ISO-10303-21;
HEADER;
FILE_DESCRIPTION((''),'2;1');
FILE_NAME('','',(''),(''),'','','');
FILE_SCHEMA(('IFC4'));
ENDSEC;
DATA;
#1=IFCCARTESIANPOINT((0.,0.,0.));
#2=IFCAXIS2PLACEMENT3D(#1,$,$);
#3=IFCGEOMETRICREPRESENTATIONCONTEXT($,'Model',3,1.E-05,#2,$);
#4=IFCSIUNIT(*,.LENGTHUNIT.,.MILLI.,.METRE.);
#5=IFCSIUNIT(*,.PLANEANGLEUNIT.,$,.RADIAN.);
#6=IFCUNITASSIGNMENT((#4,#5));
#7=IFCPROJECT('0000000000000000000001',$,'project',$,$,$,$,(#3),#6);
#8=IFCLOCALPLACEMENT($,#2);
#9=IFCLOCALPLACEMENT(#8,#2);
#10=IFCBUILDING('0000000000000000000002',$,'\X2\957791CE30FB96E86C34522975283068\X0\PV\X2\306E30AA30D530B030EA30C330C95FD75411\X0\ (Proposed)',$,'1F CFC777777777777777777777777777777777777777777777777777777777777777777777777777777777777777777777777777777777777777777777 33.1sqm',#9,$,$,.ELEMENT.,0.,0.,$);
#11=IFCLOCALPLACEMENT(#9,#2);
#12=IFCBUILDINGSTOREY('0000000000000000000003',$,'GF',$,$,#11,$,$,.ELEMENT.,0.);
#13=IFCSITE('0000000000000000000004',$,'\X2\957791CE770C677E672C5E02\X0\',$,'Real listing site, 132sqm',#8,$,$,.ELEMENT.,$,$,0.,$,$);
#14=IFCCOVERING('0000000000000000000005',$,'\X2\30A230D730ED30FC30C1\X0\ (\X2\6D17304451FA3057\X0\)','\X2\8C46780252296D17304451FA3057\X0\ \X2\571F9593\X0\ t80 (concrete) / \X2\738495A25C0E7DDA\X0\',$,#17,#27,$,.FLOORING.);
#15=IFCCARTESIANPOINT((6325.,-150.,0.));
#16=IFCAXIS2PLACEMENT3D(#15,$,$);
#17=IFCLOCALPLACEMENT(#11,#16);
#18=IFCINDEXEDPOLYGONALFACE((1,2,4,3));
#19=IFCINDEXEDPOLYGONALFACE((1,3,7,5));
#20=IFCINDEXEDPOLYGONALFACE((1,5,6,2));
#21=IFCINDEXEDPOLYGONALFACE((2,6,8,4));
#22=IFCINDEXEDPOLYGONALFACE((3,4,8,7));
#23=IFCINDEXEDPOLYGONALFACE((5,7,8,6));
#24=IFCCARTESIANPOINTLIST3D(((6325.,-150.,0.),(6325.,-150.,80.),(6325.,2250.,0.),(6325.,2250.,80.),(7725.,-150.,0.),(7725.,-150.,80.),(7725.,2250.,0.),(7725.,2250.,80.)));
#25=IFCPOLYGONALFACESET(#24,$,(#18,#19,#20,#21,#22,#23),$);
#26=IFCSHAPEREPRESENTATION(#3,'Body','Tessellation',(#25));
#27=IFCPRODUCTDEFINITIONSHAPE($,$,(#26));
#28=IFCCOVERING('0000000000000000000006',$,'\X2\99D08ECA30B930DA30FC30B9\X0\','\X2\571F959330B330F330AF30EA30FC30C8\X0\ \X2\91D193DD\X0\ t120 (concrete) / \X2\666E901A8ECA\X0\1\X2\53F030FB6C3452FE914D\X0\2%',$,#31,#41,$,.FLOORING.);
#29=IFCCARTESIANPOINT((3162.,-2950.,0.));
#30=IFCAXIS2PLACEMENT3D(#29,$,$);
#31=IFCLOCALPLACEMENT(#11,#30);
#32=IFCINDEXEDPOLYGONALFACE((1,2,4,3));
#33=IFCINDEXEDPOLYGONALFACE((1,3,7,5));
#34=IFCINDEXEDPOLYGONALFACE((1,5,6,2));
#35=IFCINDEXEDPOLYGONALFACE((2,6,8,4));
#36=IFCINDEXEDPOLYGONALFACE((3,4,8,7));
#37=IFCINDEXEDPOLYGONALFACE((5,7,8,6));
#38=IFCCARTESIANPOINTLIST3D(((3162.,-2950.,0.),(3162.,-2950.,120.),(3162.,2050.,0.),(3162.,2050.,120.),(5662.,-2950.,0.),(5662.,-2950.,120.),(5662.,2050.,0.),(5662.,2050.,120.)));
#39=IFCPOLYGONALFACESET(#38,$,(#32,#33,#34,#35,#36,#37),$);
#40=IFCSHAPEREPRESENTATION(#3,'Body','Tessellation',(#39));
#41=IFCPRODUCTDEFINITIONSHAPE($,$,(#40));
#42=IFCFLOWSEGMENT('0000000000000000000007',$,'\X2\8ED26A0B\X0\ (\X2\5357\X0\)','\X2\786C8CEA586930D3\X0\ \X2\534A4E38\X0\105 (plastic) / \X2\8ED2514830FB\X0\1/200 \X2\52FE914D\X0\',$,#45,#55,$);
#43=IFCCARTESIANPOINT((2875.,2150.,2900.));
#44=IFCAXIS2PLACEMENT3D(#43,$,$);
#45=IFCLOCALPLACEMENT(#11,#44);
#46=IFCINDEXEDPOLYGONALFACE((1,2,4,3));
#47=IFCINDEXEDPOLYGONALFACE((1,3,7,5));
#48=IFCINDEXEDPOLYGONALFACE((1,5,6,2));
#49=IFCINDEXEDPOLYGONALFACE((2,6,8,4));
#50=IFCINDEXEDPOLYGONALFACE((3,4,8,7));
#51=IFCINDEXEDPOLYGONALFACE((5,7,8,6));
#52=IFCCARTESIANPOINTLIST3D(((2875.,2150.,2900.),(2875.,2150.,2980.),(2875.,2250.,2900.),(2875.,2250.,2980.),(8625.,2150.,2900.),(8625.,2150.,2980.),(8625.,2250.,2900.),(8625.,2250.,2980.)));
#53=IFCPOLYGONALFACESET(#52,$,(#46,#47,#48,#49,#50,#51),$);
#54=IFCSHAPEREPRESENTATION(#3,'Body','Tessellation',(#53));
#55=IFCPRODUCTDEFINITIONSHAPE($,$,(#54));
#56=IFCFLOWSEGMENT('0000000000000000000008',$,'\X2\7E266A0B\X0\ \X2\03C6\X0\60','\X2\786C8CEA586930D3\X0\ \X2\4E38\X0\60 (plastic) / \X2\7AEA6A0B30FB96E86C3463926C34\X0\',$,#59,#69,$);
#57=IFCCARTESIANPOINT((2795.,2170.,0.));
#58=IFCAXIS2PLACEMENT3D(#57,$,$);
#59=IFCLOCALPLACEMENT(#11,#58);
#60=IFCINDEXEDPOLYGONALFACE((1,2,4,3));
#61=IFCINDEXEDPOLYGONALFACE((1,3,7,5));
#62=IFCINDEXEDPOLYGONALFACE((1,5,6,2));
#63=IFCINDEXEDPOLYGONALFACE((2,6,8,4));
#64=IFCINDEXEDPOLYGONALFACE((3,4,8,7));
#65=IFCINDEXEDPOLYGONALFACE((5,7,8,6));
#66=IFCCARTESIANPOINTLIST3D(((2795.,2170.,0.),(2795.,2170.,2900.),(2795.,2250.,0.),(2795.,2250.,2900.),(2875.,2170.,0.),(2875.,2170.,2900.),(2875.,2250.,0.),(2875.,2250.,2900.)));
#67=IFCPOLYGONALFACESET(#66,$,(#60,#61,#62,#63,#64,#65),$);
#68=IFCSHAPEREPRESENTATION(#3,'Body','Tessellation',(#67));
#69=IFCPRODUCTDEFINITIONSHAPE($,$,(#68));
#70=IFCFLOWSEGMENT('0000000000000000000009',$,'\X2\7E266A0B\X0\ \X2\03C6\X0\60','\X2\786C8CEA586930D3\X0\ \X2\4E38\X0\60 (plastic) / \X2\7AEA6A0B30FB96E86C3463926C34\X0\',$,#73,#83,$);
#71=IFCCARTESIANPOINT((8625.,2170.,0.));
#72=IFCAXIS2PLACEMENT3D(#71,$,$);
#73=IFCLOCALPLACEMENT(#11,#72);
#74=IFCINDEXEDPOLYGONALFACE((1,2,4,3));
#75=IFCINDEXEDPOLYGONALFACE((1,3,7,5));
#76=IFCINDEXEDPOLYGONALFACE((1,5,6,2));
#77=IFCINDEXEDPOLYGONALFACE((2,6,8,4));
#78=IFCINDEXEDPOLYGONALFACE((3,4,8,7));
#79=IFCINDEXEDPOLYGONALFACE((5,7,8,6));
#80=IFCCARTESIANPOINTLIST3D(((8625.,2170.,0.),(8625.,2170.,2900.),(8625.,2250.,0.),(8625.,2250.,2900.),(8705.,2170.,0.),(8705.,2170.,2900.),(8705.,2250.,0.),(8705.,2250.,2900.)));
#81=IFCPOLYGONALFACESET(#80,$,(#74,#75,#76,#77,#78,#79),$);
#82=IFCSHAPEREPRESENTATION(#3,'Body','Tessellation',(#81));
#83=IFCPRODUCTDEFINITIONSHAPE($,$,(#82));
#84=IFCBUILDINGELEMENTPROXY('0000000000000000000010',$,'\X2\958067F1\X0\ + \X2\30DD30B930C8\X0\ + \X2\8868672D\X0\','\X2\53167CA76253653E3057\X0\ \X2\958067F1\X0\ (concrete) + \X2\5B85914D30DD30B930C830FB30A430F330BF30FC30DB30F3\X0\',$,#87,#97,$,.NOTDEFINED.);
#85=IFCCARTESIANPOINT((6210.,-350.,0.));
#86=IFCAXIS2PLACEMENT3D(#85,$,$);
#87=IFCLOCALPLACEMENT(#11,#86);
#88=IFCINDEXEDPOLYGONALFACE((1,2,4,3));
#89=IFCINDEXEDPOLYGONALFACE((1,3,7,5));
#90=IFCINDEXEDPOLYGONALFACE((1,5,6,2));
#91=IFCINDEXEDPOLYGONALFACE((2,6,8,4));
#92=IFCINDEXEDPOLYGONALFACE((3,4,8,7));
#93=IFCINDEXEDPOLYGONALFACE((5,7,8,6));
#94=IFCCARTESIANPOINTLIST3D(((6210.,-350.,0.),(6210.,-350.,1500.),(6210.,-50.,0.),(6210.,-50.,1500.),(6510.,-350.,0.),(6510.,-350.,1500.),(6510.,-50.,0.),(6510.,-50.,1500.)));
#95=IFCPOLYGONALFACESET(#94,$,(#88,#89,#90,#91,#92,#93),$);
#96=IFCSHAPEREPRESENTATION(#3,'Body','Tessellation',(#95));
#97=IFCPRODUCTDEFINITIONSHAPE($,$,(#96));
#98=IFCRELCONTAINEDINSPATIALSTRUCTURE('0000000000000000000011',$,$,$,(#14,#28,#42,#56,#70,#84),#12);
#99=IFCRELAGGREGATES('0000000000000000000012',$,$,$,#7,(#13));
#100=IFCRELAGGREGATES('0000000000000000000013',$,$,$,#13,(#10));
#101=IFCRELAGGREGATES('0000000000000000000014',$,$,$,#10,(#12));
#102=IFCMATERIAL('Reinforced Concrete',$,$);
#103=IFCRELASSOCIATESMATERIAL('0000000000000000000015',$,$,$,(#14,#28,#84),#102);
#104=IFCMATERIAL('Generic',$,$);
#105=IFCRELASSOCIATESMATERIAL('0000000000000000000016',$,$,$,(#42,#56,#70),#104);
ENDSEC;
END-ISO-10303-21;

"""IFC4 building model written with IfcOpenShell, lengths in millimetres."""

from ifc_helpers import new_model, si_unit, frame, frame_2d, origin, place, context, project, spatial, rectangle, extrude, material, element, save


model = new_model("IFC4")

# Units and contexts
model_context = context("Model", 3, precision=1e-05, world=origin())
ifc_project = project(units=[si_unit("LENGTHUNIT", "METRE", prefix="MILLI"), si_unit("PLANEANGLEUNIT", "RADIAN")], contexts=[model_context])

# Site, building, storey
site_placement = place(None, origin())
site = spatial("IfcSite", under=ifc_project, at=site_placement, Name="長野県松本市", ObjectType="Real listing site, 132sqm", CompositionType="ELEMENT", RefElevation=0.0)
building_placement = place(site_placement, origin())
building = spatial("IfcBuilding", under=site, at=building_placement, Name="長野・雨水利用とPVのオフグリッド志向 (Proposed)", ObjectType="1F CFC777777777777777777777777777777777777777777777777777777777777777777777777777777777777777777777777777777777777777777777 33.1sqm", CompositionType="ELEMENT", ElevationOfRefHeight=0.0, ElevationOfTerrain=0.0)
storey_placement = place(building_placement, origin())
storey = spatial("IfcBuildingStorey", under=building, at=storey_placement, Name="GF", CompositionType="ELEMENT", Elevation=0.0)

# Shared definitions
ifc_material_1 = material(Name="Reinforced Concrete")

# Coverings
ifc_material_2 = material(Name="Generic")
covering_1_placement = place(storey_placement, frame((6325.0, -150.0, 0.0)))
element("IfcCovering", 1, at=covering_1_placement, inside=storey, material=ifc_material_1, Name="アプローチ (洗い出し)", Description="豆砂利洗い出し 土間 t80 (concrete) / 玄関導線", PredefinedType="FLOORING", context=model_context, shape_type="SweptSolid", body=[
    extrude(rectangle(XDim=1400.0, YDim=2400.0, at=frame_2d((700.0, 1200.0))), frame((6325.0, -150.0, 0.0)), (0.0, 0.0, 1.0), 80.0),
])
covering_2_placement = place(storey_placement, frame((3162.0, -2950.0, 0.0)))
element("IfcCovering", 2, at=covering_2_placement, inside=storey, material=ifc_material_1, Name="駐車スペース", Description="土間コンクリート 金鏝 t120 (concrete) / 普通車1台・水勾配2%", PredefinedType="FLOORING", context=model_context, shape_type="SweptSolid", body=[
    extrude(rectangle(XDim=2500.0, YDim=5000.0, at=frame_2d((1250.0, 2500.0))), frame((3162.0, -2950.0, 0.0)), (0.0, 0.0, 1.0), 120.0),
])

# Flow segments
flow_segment_1_placement = place(storey_placement, frame((2875.0, 2150.0, 2900.0)))
element("IfcFlowSegment", 3, at=flow_segment_1_placement, inside=storey, material=ifc_material_2, Name="軒樋 (南)", Description="硬質塩ビ 半丸105 (plastic) / 軒先・1/200 勾配", context=model_context, shape_type="SweptSolid", body=[
    extrude(rectangle(XDim=5750.0, YDim=100.0, at=frame_2d((2875.0, 50.0))), frame((2875.0, 2150.0, 2900.0)), (0.0, 0.0, 1.0), 80.0),
])
flow_segment_2_placement = place(storey_placement, frame((2795.0, 2170.0, 0.0)))
element("IfcFlowSegment", 4, at=flow_segment_2_placement, inside=storey, material=ifc_material_2, Name="縦樋 φ60", Description="硬質塩ビ 丸60 (plastic) / 竪樋・雨水排水", context=model_context, shape_type="SweptSolid", body=[
    extrude(rectangle(XDim=80.0, YDim=80.0, at=frame_2d((40.0, 40.0))), frame((2795.0, 2170.0, 0.0)), (0.0, 0.0, 1.0), 2900.0),
])
flow_segment_3_placement = place(storey_placement, frame((8625.0, 2170.0, 0.0)))
element("IfcFlowSegment", 5, at=flow_segment_3_placement, inside=storey, material=ifc_material_2, Name="縦樋 φ60", Description="硬質塩ビ 丸60 (plastic) / 竪樋・雨水排水", context=model_context, shape_type="SweptSolid", body=[
    extrude(rectangle(XDim=80.0, YDim=80.0, at=frame_2d((40.0, 40.0))), frame((8625.0, 2170.0, 0.0)), (0.0, 0.0, 1.0), 2900.0),
])

# Building element proxy
proxy_placement = place(storey_placement, frame((6210.0, -350.0, 0.0)))
element("IfcBuildingElementProxy", 6, at=proxy_placement, inside=storey, material=ifc_material_1, Name="門柱 + ポスト + 表札", Description="化粧打放し 門柱 (concrete) + 宅配ポスト・インターホン", PredefinedType="NOTDEFINED", context=model_context, shape_type="SweptSolid", body=[
    extrude(rectangle(XDim=300.0, YDim=300.0, at=frame_2d((150.0, 150.0))), frame((6210.0, -350.0, 0.0)), (0.0, 0.0, 1.0), 1500.0),
])

save(model, "model.ifc")
